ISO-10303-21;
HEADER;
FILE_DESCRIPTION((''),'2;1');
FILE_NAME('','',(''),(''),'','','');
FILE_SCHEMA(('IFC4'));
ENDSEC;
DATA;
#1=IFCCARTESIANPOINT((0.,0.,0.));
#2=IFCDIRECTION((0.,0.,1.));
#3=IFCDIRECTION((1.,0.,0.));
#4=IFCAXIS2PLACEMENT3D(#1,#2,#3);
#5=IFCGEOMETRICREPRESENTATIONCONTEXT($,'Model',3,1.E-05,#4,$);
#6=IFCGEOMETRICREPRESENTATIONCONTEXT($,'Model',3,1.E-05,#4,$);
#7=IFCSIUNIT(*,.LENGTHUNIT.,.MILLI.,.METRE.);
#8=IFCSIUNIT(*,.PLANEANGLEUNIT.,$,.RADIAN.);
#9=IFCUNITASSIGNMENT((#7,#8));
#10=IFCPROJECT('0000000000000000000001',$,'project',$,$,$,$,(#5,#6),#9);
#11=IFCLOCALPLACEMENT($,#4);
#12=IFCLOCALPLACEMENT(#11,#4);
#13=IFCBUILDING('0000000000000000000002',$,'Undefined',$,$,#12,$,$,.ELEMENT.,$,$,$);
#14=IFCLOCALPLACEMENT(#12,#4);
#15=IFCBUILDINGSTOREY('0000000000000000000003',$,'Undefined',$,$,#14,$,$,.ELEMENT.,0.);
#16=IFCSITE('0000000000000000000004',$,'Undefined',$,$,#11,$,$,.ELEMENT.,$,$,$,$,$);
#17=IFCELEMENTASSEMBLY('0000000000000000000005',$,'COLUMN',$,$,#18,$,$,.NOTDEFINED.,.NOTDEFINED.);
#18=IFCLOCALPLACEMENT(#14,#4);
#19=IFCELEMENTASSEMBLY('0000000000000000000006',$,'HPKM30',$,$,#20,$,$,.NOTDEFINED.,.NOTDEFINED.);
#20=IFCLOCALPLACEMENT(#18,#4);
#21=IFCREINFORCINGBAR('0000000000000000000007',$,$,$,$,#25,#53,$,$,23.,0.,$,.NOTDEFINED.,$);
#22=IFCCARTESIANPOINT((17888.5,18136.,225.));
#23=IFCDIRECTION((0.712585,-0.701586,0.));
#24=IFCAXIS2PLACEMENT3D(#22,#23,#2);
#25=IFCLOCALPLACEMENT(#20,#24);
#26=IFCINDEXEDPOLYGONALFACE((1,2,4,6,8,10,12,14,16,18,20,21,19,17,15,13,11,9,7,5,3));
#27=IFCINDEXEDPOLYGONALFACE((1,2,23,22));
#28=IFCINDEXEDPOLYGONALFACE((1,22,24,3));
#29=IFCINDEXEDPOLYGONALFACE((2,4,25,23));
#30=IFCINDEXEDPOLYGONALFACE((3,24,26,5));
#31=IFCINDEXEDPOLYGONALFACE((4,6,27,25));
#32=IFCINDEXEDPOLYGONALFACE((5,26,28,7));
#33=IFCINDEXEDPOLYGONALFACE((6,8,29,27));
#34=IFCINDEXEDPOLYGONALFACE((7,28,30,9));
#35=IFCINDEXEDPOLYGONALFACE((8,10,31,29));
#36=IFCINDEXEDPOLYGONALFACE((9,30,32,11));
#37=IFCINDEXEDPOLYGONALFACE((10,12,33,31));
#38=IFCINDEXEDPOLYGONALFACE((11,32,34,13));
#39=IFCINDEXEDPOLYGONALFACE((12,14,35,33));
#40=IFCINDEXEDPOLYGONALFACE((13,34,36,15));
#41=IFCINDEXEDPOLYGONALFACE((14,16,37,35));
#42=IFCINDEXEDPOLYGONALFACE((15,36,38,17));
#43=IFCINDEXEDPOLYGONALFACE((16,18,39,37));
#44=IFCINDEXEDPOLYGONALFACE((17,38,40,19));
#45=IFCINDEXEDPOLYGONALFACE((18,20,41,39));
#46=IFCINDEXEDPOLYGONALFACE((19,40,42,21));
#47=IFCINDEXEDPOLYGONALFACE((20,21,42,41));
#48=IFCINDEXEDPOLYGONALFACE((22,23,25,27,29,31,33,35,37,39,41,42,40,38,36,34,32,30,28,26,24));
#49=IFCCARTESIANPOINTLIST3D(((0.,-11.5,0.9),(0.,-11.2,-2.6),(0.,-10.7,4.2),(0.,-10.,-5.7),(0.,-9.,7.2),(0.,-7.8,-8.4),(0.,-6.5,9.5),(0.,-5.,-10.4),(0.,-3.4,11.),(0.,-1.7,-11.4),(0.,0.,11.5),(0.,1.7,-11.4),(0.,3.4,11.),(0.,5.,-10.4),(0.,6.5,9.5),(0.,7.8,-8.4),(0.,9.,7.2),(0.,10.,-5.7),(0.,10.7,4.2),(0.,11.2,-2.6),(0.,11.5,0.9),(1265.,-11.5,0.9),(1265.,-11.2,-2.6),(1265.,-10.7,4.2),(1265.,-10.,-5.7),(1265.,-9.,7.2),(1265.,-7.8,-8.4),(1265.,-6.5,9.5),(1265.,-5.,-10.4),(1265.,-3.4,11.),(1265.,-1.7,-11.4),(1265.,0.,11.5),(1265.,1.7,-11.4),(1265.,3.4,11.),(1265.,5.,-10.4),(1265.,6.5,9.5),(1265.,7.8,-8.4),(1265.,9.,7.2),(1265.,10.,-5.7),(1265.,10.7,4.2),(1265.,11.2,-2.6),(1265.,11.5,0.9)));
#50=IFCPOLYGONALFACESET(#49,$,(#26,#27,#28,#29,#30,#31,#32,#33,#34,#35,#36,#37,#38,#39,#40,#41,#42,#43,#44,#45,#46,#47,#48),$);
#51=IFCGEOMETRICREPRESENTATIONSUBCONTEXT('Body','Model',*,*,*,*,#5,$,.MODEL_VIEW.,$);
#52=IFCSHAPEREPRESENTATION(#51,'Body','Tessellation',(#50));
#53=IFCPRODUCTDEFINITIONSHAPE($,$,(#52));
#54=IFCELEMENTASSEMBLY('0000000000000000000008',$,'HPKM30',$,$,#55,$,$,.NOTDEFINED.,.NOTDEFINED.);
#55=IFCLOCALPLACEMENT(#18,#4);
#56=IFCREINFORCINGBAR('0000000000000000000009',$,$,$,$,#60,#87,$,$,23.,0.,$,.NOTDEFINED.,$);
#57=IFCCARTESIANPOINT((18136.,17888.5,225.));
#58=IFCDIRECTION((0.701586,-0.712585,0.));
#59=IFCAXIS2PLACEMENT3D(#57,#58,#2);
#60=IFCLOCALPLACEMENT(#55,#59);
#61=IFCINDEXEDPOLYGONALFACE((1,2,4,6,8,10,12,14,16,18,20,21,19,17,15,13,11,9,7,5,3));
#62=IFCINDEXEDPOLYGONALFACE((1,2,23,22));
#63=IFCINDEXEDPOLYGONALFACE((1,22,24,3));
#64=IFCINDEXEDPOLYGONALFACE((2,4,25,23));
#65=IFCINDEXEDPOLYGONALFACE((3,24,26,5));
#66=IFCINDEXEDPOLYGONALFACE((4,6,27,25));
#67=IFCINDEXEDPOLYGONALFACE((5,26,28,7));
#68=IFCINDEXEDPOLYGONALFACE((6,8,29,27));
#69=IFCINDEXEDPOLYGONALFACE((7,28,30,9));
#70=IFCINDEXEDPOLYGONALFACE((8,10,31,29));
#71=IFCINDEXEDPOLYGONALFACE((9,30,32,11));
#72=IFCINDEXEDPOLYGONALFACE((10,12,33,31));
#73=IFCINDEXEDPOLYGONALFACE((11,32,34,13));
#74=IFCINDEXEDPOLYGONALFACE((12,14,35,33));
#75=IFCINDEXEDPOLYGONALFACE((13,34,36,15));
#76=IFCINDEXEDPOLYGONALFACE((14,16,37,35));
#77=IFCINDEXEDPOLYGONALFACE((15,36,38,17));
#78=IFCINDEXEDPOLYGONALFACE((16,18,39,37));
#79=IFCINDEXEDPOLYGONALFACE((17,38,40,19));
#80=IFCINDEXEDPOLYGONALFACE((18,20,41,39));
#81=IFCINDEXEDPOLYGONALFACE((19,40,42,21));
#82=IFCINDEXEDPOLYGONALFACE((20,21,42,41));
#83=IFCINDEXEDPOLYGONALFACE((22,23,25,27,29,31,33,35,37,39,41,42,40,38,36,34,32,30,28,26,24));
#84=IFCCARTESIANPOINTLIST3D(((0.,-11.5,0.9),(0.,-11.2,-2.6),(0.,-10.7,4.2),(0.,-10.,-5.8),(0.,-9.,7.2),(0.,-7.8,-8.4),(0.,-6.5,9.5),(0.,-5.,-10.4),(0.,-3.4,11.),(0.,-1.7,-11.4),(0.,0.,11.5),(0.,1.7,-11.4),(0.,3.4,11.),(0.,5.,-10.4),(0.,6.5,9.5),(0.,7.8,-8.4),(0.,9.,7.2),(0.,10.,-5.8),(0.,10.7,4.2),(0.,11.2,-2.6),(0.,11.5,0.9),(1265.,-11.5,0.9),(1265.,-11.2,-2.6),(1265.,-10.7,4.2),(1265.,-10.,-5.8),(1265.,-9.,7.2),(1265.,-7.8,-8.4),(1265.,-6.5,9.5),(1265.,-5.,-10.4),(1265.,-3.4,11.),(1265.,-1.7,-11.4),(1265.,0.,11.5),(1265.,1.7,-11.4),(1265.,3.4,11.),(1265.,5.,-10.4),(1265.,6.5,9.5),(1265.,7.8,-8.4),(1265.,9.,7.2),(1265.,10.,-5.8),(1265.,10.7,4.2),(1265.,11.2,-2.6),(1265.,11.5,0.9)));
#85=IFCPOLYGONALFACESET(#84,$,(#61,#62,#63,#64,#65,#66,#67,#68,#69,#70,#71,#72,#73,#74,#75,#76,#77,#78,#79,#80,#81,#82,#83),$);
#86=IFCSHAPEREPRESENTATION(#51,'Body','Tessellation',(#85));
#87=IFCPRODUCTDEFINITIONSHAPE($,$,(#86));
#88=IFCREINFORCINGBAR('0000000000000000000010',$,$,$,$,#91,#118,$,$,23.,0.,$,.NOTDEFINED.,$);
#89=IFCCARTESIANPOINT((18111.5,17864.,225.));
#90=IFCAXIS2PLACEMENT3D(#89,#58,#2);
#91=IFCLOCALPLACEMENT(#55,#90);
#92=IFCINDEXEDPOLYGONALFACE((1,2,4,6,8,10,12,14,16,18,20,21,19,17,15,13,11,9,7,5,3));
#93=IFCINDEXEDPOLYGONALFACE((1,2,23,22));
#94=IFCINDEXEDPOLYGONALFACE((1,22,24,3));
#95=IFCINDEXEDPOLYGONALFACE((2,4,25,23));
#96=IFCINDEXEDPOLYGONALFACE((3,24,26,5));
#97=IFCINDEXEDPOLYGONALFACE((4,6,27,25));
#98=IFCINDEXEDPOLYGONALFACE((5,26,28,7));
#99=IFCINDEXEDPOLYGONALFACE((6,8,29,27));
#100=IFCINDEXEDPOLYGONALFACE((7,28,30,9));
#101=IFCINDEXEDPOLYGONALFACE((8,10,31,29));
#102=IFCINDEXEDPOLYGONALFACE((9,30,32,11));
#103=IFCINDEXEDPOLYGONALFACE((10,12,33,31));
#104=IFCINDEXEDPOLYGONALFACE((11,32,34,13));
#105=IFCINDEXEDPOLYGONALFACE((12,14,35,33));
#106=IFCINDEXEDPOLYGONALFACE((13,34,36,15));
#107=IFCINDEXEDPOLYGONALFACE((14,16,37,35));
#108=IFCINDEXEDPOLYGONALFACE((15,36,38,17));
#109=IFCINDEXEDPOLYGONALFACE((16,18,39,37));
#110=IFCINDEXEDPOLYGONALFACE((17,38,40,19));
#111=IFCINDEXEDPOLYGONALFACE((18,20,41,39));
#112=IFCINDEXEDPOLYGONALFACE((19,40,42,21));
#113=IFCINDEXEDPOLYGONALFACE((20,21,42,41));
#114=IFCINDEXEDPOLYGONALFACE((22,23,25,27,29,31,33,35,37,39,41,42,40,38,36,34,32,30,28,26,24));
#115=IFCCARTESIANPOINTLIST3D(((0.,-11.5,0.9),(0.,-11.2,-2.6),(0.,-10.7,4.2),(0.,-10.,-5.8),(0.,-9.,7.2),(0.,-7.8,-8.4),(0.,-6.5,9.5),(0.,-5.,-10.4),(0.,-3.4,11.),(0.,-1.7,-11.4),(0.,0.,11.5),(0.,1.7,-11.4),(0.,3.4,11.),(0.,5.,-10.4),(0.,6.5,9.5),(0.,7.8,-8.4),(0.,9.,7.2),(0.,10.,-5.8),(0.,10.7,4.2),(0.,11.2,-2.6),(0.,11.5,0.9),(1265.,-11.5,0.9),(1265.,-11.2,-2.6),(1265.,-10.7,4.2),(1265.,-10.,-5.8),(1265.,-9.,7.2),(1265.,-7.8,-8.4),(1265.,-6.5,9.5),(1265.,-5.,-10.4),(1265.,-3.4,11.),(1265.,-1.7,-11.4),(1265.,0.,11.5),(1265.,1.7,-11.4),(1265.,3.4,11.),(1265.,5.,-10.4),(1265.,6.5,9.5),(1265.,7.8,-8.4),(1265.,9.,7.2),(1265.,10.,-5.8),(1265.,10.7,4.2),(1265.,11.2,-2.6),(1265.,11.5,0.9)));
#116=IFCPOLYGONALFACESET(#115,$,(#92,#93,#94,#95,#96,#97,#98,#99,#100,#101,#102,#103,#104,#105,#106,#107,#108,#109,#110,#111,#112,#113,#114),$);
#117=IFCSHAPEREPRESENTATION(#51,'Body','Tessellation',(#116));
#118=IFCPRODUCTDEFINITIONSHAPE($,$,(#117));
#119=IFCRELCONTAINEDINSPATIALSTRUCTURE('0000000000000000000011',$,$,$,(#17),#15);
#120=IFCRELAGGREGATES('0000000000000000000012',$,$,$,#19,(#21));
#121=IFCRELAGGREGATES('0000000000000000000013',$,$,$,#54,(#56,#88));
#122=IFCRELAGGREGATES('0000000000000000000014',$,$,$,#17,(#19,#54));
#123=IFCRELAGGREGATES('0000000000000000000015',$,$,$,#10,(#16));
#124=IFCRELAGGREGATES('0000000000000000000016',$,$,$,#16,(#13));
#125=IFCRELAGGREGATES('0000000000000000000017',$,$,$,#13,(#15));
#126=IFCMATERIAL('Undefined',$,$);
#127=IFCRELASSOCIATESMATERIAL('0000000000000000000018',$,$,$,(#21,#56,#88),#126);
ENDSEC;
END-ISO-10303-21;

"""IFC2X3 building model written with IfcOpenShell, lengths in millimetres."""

from ifc_helpers import new_model, entity, si_unit, frame, origin_with_axes, place, context, subcontext, project, spatial, source, transform, mapped, material, element, aggregate, save


model = new_model("IFC2X3")

# Units and contexts
model_context_1 = context("Model", 3, precision=1e-05, world=origin_with_axes())
model_context_2 = context("Model", 3, precision=1e-05, world=origin_with_axes())
body_context = subcontext(model_context_1, "Body", "Model", "MODEL_VIEW")
ifc_project = project(units=[si_unit("LENGTHUNIT", "METRE", prefix="MILLI"), si_unit("PLANEANGLEUNIT", "RADIAN")], contexts=[model_context_1, model_context_2])

# Site, building, storey
site_placement = place(None, origin_with_axes())
site = spatial("IfcSite", under=ifc_project, at=site_placement, Name="Undefined", CompositionType="ELEMENT")
building_placement = place(site_placement, origin_with_axes())
building = spatial("IfcBuilding", under=site, at=building_placement, Name="Undefined", CompositionType="ELEMENT")
storey_placement = place(building_placement, origin_with_axes())
storey = spatial("IfcBuildingStorey", under=building, at=storey_placement, Name="Undefined", CompositionType="ELEMENT", Elevation=0.0)

# Element assembly
assembly_1_placement = place(storey_placement, origin_with_axes())
assembly_1 = element("IfcElementAssembly", 1, at=assembly_1_placement, inside=storey, Name="COLUMN", AssemblyPlace="NOTDEFINED", PredefinedType="NOTDEFINED")

# Shared definitions
ifc_material_1 = material(Name="Undefined")

# Element assemblies, reinforcing bars
assembly_2_placement = place(assembly_1_placement, origin_with_axes())
assembly_2 = element("IfcElementAssembly", 2, at=assembly_2_placement, Name="HPKM30", AssemblyPlace="NOTDEFINED", PredefinedType="NOTDEFINED")
shared_shape_1 = source(origin_with_axes(), body_context, "Body", "AdvancedSweptSolid", [
    entity("IfcSweptDiskSolid", entity("IfcTrimmedCurve", entity("IfcLine", entity("IfcCartesianPoint", [0.0, 0.0, 0.0]), entity("IfcVector", entity("IfcDirection", [1.0, 0.0, 0.0]), 1.0)), [entity("IfcParameterValue", 0.0)], [entity("IfcParameterValue", 1265.0)], True, "PARAMETER"), 11.5, None, 0.0, 1265.0),
])
reinforcing_bar_1_placement = place(assembly_2_placement, frame((17888.5, 18136.0, 225.0), z_axis=(0.712585, -0.701586, 0.0), x_axis=(0.0, 0.0, 1.0)))
reinforcing_bar_1 = element("IfcReinforcingBar", 3, at=reinforcing_bar_1_placement, material=ifc_material_1, BarRole="NOTDEFINED", CrossSectionArea=0.0, NominalDiameter=23.0, context=body_context, shape_type="MappedRepresentation", body=[
    mapped(shared_shape_1, transform((0.0, 0.0, 0.0))),
])
aggregate(assembly_2, [reinforcing_bar_1])
assembly_3_placement = place(assembly_1_placement, origin_with_axes())
assembly_3 = element("IfcElementAssembly", 4, at=assembly_3_placement, Name="HPKM30", AssemblyPlace="NOTDEFINED", PredefinedType="NOTDEFINED")
shared_shape_2 = source(origin_with_axes(), body_context, "Body", "AdvancedSweptSolid", [
    entity("IfcSweptDiskSolid", entity("IfcTrimmedCurve", entity("IfcLine", entity("IfcCartesianPoint", [0.0, 0.0, 0.0]), entity("IfcVector", entity("IfcDirection", [1.0, 0.0, 0.0]), 1.0)), [entity("IfcParameterValue", 0.0)], [entity("IfcParameterValue", 1265.0)], True, "PARAMETER"), 11.5, None, 0.0, 1265.0),
])
reinforcing_bar_2_placement = place(assembly_3_placement, frame((18136.0, 17888.5, 225.0), z_axis=(0.701586, -0.712585, 0.0), x_axis=(0.0, 0.0, 1.0)))
reinforcing_bar_2 = element("IfcReinforcingBar", 5, at=reinforcing_bar_2_placement, material=ifc_material_1, BarRole="NOTDEFINED", CrossSectionArea=0.0, NominalDiameter=23.0, context=body_context, shape_type="MappedRepresentation", body=[
    mapped(shared_shape_2, transform((0.0, 0.0, 0.0))),
])
shared_shape_3 = source(origin_with_axes(), body_context, "Body", "AdvancedSweptSolid", [
    entity("IfcSweptDiskSolid", entity("IfcTrimmedCurve", entity("IfcLine", entity("IfcCartesianPoint", [0.0, 0.0, 0.0]), entity("IfcVector", entity("IfcDirection", [1.0, 0.0, 0.0]), 1.0)), [entity("IfcParameterValue", 0.0)], [entity("IfcParameterValue", 1265.0)], True, "PARAMETER"), 11.5, None, 0.0, 1265.0),
])
reinforcing_bar_3_placement = place(assembly_3_placement, frame((18111.5, 17864.0, 225.0), z_axis=(0.701586, -0.712585, 0.0), x_axis=(0.0, 0.0, 1.0)))
reinforcing_bar_3 = element("IfcReinforcingBar", 6, at=reinforcing_bar_3_placement, material=ifc_material_1, BarRole="NOTDEFINED", CrossSectionArea=0.0, NominalDiameter=23.0, context=body_context, shape_type="MappedRepresentation", body=[
    mapped(shared_shape_3, transform((0.0, 0.0, 0.0))),
])
aggregate(assembly_3, [reinforcing_bar_2, reinforcing_bar_3])

aggregate(assembly_1, [assembly_2, assembly_3])

save(model, "model.ifc")
